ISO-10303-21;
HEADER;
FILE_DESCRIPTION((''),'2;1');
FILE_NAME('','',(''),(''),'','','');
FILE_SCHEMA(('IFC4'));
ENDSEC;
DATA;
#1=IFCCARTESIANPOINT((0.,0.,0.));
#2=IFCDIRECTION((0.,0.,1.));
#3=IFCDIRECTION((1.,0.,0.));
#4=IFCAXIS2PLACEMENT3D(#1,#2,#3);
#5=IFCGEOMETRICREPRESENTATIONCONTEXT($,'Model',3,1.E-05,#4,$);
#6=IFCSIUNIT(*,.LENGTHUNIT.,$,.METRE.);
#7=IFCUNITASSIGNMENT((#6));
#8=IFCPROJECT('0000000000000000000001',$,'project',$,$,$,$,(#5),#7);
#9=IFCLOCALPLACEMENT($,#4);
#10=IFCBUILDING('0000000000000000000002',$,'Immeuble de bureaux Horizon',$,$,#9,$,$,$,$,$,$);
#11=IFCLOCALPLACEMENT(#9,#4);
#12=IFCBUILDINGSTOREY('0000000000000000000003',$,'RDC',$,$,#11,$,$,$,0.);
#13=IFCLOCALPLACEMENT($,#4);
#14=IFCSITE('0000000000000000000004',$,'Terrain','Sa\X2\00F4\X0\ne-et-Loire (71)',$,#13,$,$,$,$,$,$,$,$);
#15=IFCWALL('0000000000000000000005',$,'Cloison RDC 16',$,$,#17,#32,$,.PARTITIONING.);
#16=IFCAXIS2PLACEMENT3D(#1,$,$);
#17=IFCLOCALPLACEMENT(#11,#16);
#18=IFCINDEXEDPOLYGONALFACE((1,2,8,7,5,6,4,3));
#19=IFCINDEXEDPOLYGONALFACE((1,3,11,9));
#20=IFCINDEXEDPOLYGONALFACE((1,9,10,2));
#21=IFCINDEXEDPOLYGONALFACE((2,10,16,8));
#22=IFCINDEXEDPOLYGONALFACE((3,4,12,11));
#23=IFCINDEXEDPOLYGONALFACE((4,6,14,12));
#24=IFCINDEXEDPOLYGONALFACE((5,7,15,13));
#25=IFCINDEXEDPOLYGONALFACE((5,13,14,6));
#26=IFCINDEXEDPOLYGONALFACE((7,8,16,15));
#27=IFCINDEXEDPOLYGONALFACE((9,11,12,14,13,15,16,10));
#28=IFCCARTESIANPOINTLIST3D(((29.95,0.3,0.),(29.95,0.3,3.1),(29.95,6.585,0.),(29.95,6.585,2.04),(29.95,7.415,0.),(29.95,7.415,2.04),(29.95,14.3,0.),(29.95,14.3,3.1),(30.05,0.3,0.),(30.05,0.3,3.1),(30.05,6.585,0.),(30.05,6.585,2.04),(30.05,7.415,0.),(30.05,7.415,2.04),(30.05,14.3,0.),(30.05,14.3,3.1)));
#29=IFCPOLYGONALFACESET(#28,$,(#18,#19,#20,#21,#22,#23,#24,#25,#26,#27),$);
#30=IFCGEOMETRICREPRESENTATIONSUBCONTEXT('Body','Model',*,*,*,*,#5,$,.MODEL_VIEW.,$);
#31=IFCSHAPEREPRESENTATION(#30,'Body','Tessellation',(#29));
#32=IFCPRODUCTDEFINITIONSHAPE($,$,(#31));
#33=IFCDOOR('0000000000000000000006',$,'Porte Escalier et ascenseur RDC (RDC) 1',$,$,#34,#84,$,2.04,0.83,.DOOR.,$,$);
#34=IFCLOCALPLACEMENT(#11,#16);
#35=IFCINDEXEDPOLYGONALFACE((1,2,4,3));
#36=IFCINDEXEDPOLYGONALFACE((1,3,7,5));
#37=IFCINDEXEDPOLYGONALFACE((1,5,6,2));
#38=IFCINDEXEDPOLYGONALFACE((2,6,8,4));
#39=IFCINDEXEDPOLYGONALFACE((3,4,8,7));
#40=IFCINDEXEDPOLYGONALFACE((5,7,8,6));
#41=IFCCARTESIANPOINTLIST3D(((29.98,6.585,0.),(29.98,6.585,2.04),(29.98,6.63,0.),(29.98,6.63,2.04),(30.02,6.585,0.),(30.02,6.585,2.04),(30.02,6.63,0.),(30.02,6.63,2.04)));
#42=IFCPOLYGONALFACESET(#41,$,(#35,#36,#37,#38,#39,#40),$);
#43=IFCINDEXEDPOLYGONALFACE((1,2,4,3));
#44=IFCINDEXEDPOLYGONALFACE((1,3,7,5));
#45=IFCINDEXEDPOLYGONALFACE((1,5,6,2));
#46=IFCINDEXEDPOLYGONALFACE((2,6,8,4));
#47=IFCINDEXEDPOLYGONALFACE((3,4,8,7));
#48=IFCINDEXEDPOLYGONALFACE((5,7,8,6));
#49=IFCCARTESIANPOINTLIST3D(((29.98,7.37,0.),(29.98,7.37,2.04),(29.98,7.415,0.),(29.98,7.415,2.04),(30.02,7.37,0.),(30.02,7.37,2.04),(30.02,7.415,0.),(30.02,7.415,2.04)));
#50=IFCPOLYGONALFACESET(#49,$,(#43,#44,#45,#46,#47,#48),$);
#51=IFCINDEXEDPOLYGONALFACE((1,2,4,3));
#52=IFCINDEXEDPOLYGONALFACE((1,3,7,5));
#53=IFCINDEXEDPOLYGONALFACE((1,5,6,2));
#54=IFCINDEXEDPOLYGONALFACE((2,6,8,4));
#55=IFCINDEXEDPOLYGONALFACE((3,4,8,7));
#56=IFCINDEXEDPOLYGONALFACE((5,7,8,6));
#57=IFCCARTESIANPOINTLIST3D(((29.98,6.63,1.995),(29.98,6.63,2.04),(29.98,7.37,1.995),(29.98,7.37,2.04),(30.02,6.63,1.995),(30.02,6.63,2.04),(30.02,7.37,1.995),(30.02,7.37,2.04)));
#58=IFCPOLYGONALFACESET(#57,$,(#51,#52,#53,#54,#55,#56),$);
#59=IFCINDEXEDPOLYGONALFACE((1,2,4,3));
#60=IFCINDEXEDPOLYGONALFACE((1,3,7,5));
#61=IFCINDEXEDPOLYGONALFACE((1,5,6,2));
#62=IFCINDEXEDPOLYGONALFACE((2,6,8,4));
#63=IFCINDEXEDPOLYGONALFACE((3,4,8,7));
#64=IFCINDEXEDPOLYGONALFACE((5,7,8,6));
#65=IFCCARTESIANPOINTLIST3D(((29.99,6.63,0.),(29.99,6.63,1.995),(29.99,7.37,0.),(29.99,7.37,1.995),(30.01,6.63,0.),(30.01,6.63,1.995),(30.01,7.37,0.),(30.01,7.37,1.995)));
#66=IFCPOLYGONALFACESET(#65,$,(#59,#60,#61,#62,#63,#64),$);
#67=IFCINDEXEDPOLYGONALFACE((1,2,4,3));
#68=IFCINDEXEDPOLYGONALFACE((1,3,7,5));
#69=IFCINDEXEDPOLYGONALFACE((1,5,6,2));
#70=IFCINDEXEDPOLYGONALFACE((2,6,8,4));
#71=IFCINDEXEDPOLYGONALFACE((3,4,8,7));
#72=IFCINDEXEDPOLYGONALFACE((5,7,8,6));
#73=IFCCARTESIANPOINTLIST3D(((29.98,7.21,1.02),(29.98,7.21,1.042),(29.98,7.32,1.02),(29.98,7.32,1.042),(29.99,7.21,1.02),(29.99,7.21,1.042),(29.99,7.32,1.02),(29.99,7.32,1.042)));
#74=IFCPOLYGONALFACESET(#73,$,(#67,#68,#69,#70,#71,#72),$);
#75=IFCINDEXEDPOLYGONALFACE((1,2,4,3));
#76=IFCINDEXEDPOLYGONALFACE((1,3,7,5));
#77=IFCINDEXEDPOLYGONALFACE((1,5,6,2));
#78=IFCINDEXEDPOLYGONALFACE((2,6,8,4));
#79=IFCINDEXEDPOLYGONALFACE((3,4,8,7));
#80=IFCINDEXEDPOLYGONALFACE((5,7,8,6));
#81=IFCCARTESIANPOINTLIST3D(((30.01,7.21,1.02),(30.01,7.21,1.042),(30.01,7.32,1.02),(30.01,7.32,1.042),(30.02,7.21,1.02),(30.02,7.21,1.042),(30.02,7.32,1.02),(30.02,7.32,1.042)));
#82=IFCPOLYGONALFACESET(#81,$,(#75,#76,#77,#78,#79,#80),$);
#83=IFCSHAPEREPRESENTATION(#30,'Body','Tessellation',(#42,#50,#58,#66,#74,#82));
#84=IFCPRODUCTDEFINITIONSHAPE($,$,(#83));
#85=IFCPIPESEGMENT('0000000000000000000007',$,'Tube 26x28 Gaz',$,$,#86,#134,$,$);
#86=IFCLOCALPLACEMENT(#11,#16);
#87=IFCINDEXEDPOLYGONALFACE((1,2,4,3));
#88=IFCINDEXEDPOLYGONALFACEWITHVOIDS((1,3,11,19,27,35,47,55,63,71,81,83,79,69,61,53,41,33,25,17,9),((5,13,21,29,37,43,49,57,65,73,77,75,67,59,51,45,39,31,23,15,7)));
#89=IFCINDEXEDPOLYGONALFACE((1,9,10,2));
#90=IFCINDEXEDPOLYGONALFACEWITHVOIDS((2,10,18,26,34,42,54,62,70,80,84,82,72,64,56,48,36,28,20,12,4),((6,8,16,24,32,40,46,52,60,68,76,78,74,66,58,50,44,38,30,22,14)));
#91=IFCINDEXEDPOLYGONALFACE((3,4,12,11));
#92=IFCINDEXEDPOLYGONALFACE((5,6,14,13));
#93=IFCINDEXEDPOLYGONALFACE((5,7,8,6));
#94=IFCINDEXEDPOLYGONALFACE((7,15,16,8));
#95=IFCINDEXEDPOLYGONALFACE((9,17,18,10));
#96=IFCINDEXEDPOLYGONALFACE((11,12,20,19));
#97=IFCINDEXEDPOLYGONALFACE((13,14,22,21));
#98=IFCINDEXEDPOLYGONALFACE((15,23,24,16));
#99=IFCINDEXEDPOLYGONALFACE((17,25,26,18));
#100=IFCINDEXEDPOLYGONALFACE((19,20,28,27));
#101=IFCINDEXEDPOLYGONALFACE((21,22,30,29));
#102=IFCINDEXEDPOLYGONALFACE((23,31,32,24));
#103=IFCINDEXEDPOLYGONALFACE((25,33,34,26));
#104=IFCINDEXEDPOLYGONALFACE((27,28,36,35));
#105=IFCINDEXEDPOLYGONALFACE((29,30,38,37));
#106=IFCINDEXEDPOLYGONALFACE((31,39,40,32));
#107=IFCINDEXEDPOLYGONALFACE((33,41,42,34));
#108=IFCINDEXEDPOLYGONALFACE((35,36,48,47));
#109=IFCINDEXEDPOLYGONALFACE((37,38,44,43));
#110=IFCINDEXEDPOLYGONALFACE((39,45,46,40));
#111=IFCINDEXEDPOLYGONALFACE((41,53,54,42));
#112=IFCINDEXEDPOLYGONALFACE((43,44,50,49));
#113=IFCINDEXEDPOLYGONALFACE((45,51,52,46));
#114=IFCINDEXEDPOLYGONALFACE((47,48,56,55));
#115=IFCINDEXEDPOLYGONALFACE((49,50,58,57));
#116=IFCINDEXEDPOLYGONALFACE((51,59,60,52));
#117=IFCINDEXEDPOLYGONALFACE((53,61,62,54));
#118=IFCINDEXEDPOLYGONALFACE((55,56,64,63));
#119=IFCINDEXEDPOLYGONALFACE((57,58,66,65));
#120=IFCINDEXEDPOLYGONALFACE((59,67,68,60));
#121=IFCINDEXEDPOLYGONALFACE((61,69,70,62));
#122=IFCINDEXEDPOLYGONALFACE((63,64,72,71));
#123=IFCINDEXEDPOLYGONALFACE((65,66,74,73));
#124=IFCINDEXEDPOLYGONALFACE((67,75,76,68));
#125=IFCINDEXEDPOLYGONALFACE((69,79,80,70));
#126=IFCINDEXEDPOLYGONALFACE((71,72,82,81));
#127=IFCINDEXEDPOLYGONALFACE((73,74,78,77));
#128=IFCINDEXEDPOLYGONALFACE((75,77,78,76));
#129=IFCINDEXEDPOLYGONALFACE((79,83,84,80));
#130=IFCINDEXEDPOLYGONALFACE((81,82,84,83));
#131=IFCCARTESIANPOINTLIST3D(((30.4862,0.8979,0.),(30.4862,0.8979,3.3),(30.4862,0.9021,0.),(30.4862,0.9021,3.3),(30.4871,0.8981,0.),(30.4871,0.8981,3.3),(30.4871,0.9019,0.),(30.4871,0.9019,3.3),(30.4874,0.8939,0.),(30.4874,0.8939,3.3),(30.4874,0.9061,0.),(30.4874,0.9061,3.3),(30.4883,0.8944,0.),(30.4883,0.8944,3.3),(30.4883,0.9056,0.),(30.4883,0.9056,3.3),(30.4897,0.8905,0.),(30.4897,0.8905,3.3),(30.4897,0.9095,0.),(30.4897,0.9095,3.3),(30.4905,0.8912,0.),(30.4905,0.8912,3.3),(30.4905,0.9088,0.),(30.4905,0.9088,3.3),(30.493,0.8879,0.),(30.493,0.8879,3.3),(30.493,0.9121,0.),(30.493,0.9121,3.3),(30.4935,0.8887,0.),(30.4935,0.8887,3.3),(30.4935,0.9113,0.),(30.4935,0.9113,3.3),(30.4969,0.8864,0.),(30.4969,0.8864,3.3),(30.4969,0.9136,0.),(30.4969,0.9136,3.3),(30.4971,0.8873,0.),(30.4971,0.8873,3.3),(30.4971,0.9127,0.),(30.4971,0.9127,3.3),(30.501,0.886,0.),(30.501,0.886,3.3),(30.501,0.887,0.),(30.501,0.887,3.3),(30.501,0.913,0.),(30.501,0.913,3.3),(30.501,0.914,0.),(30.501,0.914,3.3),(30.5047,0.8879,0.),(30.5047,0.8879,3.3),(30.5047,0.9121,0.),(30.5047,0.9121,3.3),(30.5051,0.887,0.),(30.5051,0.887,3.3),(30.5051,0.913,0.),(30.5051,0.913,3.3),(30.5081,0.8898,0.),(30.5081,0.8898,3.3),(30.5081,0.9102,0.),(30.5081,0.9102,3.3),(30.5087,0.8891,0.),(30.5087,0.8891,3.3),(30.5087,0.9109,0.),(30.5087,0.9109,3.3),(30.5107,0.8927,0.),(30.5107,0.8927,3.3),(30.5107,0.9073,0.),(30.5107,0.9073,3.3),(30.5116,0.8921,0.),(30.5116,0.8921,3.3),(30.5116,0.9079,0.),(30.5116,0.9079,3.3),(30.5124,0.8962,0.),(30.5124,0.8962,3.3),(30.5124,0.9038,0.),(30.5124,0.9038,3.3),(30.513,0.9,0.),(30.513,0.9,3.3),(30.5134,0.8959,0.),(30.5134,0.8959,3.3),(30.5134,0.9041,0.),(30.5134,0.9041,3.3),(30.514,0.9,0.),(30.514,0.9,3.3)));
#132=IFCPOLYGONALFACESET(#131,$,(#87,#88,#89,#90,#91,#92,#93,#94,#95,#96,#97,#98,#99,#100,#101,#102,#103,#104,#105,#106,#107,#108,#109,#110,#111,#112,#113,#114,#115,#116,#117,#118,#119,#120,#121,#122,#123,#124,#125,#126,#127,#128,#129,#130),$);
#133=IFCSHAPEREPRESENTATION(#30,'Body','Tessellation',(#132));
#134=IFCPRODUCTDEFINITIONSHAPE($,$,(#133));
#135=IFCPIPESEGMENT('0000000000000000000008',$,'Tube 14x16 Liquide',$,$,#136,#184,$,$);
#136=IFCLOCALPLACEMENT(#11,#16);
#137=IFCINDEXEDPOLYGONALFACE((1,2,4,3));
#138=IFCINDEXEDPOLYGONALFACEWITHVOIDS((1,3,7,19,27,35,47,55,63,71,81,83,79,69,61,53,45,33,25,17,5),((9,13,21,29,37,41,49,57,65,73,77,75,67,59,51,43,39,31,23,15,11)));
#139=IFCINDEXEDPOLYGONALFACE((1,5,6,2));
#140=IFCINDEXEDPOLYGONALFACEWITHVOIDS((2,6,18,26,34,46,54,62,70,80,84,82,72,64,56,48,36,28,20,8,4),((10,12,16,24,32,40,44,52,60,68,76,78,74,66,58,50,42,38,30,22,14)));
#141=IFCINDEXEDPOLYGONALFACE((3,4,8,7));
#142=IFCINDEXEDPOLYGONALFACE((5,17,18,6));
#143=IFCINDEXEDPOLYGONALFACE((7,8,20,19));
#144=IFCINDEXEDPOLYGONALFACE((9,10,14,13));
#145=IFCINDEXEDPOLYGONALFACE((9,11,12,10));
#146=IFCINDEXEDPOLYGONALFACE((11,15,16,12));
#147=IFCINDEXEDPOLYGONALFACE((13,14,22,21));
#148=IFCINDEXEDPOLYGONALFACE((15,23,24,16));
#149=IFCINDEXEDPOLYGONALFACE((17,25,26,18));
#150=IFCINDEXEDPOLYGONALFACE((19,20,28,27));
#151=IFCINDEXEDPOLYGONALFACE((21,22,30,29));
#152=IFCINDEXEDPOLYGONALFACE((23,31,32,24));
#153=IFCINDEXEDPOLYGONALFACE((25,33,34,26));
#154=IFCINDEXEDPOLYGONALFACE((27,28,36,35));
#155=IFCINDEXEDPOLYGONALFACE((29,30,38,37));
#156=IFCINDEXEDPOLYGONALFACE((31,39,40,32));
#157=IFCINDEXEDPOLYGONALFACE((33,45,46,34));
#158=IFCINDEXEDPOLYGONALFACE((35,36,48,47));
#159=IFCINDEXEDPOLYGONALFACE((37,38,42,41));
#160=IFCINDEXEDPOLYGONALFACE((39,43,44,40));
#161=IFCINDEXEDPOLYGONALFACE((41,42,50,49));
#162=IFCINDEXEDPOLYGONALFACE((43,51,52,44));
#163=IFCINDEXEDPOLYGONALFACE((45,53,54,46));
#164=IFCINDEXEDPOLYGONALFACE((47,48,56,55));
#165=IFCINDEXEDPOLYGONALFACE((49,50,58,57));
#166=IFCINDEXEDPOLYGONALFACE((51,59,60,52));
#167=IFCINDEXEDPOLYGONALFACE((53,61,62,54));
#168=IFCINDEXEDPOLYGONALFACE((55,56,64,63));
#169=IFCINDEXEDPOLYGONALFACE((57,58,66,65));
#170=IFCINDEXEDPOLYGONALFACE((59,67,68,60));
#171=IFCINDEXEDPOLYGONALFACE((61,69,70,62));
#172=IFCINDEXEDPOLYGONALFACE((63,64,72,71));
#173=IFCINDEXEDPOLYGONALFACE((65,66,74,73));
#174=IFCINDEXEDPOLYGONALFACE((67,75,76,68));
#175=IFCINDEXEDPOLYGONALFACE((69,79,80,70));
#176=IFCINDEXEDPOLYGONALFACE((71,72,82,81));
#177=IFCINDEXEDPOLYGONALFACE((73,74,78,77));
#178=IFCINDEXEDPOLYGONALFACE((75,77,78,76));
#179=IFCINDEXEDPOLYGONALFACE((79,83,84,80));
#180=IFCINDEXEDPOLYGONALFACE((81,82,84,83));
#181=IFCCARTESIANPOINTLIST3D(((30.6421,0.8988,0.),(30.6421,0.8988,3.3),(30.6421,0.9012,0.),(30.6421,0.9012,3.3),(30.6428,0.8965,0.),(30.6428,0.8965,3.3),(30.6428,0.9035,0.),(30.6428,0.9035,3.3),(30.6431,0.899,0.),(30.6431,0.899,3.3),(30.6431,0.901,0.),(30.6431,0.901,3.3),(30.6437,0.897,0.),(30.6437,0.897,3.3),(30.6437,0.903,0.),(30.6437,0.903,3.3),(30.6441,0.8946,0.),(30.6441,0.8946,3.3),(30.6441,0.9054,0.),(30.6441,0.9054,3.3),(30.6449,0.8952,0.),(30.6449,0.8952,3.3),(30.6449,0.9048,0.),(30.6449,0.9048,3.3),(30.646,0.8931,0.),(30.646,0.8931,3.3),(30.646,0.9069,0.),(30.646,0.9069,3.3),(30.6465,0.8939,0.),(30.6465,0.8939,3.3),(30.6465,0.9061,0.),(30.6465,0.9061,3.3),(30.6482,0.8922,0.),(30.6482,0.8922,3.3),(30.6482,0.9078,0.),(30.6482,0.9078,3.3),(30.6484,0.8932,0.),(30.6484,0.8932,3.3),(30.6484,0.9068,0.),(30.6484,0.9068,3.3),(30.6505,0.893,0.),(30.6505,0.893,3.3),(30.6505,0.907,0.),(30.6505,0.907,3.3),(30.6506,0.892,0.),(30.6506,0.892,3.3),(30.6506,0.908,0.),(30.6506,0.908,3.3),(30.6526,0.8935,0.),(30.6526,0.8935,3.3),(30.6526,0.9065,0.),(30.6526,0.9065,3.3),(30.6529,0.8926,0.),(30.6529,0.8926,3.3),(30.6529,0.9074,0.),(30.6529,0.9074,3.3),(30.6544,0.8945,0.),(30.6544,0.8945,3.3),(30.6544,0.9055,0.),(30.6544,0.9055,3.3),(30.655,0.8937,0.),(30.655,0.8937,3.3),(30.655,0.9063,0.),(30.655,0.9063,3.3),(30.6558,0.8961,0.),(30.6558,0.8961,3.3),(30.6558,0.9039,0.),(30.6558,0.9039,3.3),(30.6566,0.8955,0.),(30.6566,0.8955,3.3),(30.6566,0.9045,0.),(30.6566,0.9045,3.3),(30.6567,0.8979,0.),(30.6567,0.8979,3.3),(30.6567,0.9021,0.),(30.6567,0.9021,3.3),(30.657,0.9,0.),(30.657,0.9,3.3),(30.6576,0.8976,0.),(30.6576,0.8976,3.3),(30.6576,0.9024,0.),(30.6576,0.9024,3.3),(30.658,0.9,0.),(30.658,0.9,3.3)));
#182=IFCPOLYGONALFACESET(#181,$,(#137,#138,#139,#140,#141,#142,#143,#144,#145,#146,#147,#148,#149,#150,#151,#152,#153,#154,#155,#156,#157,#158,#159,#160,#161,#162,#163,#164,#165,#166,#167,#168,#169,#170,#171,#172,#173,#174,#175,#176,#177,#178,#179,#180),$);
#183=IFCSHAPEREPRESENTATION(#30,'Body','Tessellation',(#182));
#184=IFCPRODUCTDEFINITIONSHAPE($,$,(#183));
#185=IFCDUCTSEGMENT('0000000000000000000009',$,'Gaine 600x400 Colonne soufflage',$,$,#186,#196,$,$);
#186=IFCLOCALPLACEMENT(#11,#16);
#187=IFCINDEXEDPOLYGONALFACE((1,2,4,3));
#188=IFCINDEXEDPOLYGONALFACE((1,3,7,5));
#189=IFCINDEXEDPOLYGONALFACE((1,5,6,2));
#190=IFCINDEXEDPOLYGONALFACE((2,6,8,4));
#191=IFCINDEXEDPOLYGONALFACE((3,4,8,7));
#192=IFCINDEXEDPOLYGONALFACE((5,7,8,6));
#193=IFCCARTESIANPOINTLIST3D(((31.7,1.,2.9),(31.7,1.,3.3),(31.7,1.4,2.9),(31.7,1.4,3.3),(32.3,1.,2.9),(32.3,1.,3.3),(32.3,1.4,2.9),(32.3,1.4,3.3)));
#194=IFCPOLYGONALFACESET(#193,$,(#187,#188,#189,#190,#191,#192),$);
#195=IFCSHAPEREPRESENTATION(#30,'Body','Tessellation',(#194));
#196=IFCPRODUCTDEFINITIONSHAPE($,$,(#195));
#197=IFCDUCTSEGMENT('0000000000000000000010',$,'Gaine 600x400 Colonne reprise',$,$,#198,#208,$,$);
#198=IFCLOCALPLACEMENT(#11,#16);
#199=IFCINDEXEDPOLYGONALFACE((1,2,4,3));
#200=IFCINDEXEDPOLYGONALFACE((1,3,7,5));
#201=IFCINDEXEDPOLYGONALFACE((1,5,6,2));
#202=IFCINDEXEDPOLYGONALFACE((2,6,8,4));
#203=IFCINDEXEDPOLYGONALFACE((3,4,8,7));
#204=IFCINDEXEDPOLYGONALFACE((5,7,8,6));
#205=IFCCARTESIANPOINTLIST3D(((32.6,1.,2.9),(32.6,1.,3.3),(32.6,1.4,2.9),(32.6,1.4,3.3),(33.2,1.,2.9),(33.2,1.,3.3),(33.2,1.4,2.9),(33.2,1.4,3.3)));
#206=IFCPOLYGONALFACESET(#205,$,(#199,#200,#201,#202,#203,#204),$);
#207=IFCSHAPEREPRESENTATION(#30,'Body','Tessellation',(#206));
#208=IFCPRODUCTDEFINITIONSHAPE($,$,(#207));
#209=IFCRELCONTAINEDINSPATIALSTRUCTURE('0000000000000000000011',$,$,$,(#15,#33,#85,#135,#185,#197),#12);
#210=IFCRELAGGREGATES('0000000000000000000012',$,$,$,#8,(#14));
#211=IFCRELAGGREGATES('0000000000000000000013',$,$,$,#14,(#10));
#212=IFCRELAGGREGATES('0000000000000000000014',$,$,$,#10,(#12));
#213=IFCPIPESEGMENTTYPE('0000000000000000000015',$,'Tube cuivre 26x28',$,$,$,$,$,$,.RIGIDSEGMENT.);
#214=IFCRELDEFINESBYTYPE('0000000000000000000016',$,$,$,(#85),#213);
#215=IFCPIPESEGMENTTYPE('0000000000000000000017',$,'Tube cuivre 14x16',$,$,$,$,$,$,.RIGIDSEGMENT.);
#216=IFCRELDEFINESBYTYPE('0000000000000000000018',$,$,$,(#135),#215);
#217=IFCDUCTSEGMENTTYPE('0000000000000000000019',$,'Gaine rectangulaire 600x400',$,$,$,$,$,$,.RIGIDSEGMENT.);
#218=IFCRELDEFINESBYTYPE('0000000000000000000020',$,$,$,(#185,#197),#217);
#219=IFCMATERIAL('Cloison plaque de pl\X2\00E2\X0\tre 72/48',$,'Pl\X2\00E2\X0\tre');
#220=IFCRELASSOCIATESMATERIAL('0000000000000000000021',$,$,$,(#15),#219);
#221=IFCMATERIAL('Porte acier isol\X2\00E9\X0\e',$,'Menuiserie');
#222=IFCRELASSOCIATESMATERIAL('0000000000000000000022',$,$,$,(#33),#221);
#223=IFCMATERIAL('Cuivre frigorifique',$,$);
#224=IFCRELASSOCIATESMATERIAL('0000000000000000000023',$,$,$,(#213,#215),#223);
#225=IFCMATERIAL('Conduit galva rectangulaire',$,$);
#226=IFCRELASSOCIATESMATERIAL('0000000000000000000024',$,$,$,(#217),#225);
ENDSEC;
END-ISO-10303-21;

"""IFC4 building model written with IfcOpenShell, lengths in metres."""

from ifc_helpers import new_model, si_unit, frame, frame_2d, origin_with_axes, origin_2d, place, context, subcontext, project, spatial, rectangle, hollow_circle, extrude, material, type_object, element, fill, save


model = new_model("IFC4")

# Units and contexts
model_context = context("Model", 3, precision=1e-05, world=origin_with_axes())
body_context = subcontext(model_context, "Body", "Model", "MODEL_VIEW")
ifc_project = project(units=[si_unit("LENGTHUNIT", "METRE")], contexts=[model_context])

# Site, building, storey
site_placement = place(None, origin_with_axes())
site = spatial("IfcSite", under=ifc_project, at=site_placement, Name="Terrain", Description="Saône-et-Loire (71)")
building_placement = place(None, origin_with_axes())
building = spatial("IfcBuilding", under=site, at=building_placement, Name="Immeuble de bureaux Horizon")
storey_placement = place(building_placement, origin_with_axes())
storey = spatial("IfcBuildingStorey", under=building, at=storey_placement, Name="RDC", Elevation=0.0)

# Shared definitions
ifc_material_1 = material(Name="Porte acier isolée", Category="Menuiserie")

# Wall, opening, door
ifc_material_2 = material(Name="Cloison plaque de plâtre 72/48", Category="Plâtre")
wall_1_placement = place(storey_placement, frame((29.95, 0.3, 0.0), z_axis=(0.0, 0.0, 1.0), x_axis=(1.0, 0.0, 0.0)))
wall_1 = element("IfcWall", 1, at=wall_1_placement, inside=storey, material=ifc_material_2, Name="Cloison RDC 16", PredefinedType="PARTITIONING", context=body_context, shape_type="SweptSolid", body=[
    extrude(rectangle(XDim=0.1, YDim=14.0, at=frame_2d((0.05, 7.0))), origin_with_axes(), (0.0, 0.0, 1.0), 3.1),
])
opening_1_placement = place(storey_placement, frame((29.9, 6.585, 0.0), z_axis=(0.0, 0.0, 1.0), x_axis=(1.0, 0.0, 0.0)))
opening_1 = element("IfcOpeningElement", 2, at=opening_1_placement, cuts=wall_1, context=body_context, shape_type="SweptSolid", body=[
    extrude(rectangle(XDim=0.2, YDim=0.83, at=frame_2d((0.1, 0.415))), origin_with_axes(), (0.0, 0.0, 1.0), 2.04),
])
door_1_placement = place(storey_placement, frame((29.98, 6.585, 0.0), z_axis=(0.0, 0.0, 1.0), x_axis=(1.0, 0.0, 0.0)))
door_1 = element("IfcDoor", 3, at=door_1_placement, inside=storey, material=ifc_material_1, Name="Porte Escalier et ascenseur RDC (RDC) 1", OverallHeight=2.04, OverallWidth=0.83, PredefinedType="DOOR", context=body_context, shape_type="SweptSolid", body=[
    extrude(rectangle(XDim=0.04, YDim=0.045, at=frame_2d((0.02, 0.0225))), origin_with_axes(), (0.0, 0.0, 1.0), 2.04),
    extrude(rectangle(XDim=0.04, YDim=0.045, at=frame_2d((0.02, 0.0225))), frame((0.0, 0.785, 0.0), z_axis=(0.0, 0.0, 1.0), x_axis=(1.0, 0.0, 0.0)), (0.0, 0.0, 1.0), 2.04),
    extrude(rectangle(XDim=0.04, YDim=0.74, at=frame_2d((0.02, 0.37))), frame((0.0, 0.045, 1.995), z_axis=(0.0, 0.0, 1.0), x_axis=(1.0, 0.0, 0.0)), (0.0, 0.0, 1.0), 0.045),
    extrude(rectangle(XDim=0.02, YDim=0.74, at=frame_2d((0.01, 0.37))), frame((0.01, 0.045, 0.0), z_axis=(0.0, 0.0, 1.0), x_axis=(1.0, 0.0, 0.0)), (0.0, 0.0, 1.0), 1.995),
    extrude(rectangle(XDim=0.01, YDim=0.11, at=frame_2d((0.005, 0.055))), frame((0.0, 0.625, 1.02), z_axis=(0.0, 0.0, 1.0), x_axis=(1.0, 0.0, 0.0)), (0.0, 0.0, 1.0), 0.022),
    extrude(rectangle(XDim=0.01, YDim=0.11, at=frame_2d((0.005, 0.055))), frame((0.03, 0.625, 1.02), z_axis=(0.0, 0.0, 1.0), x_axis=(1.0, 0.0, 0.0)), (0.0, 0.0, 1.0), 0.022),
])
fill(opening_1, door_1)

# Pipe segments
ifc_material_3 = material(Name="Cuivre frigorifique")
pipe_segment_type_1 = type_object("IfcPipeSegmentType", Name="Tube cuivre 26x28", PredefinedType="RIGIDSEGMENT", material=ifc_material_3)
pipe_segment_1_placement = place(storey_placement, frame((30.5, 0.9, 0.0), z_axis=(0.0, 0.0, 1.0), x_axis=(1.0, 0.0, 0.0)))
element("IfcPipeSegment", 4, at=pipe_segment_1_placement, inside=storey, type_object=pipe_segment_type_1, Name="Tube 26x28 Gaz", context=body_context, shape_type="SweptSolid", body=[
    extrude(hollow_circle(Radius=0.014, WallThickness=0.001), origin_with_axes(), (0.0, 0.0, 1.0), 3.3),
])
pipe_segment_type_2 = type_object("IfcPipeSegmentType", Name="Tube cuivre 14x16", PredefinedType="RIGIDSEGMENT", material=ifc_material_3)
pipe_segment_2_placement = place(storey_placement, frame((30.65, 0.9, 0.0), z_axis=(0.0, 0.0, 1.0), x_axis=(1.0, 0.0, 0.0)))
element("IfcPipeSegment", 5, at=pipe_segment_2_placement, inside=storey, type_object=pipe_segment_type_2, Name="Tube 14x16 Liquide", context=body_context, shape_type="SweptSolid", body=[
    extrude(hollow_circle(Radius=0.008, WallThickness=0.001), origin_with_axes(), (0.0, 0.0, 1.0), 3.3),
])

# Duct segments
ifc_material_4 = material(Name="Conduit galva rectangulaire")
duct_segment_type_1 = type_object("IfcDuctSegmentType", Name="Gaine rectangulaire 600x400", PredefinedType="RIGIDSEGMENT", material=ifc_material_4)
for number, where, z_axis, x_axis, name in (
    (6, (32.0, 1.2, 2.9), (0.0, 0.0, 1.0), (1.0, 0.0, 0.0), "Gaine 600x400 Colonne soufflage"),
    (7, (32.9, 1.2, 2.9), (0.0, 0.0, 1.0), (1.0, 0.0, 0.0), "Gaine 600x400 Colonne reprise"),
):
    element("IfcDuctSegment", number, at=place(storey_placement, frame(where, z_axis=z_axis, x_axis=x_axis)), inside=storey, type_object=duct_segment_type_1, Name=name, context=body_context, shape_type="SweptSolid", body=[
        extrude(rectangle(XDim=0.6, YDim=0.4, at=origin_2d()), origin_with_axes(), (0.0, 0.0, 1.0), 0.4),
    ])

save(model, "model.ifc")
